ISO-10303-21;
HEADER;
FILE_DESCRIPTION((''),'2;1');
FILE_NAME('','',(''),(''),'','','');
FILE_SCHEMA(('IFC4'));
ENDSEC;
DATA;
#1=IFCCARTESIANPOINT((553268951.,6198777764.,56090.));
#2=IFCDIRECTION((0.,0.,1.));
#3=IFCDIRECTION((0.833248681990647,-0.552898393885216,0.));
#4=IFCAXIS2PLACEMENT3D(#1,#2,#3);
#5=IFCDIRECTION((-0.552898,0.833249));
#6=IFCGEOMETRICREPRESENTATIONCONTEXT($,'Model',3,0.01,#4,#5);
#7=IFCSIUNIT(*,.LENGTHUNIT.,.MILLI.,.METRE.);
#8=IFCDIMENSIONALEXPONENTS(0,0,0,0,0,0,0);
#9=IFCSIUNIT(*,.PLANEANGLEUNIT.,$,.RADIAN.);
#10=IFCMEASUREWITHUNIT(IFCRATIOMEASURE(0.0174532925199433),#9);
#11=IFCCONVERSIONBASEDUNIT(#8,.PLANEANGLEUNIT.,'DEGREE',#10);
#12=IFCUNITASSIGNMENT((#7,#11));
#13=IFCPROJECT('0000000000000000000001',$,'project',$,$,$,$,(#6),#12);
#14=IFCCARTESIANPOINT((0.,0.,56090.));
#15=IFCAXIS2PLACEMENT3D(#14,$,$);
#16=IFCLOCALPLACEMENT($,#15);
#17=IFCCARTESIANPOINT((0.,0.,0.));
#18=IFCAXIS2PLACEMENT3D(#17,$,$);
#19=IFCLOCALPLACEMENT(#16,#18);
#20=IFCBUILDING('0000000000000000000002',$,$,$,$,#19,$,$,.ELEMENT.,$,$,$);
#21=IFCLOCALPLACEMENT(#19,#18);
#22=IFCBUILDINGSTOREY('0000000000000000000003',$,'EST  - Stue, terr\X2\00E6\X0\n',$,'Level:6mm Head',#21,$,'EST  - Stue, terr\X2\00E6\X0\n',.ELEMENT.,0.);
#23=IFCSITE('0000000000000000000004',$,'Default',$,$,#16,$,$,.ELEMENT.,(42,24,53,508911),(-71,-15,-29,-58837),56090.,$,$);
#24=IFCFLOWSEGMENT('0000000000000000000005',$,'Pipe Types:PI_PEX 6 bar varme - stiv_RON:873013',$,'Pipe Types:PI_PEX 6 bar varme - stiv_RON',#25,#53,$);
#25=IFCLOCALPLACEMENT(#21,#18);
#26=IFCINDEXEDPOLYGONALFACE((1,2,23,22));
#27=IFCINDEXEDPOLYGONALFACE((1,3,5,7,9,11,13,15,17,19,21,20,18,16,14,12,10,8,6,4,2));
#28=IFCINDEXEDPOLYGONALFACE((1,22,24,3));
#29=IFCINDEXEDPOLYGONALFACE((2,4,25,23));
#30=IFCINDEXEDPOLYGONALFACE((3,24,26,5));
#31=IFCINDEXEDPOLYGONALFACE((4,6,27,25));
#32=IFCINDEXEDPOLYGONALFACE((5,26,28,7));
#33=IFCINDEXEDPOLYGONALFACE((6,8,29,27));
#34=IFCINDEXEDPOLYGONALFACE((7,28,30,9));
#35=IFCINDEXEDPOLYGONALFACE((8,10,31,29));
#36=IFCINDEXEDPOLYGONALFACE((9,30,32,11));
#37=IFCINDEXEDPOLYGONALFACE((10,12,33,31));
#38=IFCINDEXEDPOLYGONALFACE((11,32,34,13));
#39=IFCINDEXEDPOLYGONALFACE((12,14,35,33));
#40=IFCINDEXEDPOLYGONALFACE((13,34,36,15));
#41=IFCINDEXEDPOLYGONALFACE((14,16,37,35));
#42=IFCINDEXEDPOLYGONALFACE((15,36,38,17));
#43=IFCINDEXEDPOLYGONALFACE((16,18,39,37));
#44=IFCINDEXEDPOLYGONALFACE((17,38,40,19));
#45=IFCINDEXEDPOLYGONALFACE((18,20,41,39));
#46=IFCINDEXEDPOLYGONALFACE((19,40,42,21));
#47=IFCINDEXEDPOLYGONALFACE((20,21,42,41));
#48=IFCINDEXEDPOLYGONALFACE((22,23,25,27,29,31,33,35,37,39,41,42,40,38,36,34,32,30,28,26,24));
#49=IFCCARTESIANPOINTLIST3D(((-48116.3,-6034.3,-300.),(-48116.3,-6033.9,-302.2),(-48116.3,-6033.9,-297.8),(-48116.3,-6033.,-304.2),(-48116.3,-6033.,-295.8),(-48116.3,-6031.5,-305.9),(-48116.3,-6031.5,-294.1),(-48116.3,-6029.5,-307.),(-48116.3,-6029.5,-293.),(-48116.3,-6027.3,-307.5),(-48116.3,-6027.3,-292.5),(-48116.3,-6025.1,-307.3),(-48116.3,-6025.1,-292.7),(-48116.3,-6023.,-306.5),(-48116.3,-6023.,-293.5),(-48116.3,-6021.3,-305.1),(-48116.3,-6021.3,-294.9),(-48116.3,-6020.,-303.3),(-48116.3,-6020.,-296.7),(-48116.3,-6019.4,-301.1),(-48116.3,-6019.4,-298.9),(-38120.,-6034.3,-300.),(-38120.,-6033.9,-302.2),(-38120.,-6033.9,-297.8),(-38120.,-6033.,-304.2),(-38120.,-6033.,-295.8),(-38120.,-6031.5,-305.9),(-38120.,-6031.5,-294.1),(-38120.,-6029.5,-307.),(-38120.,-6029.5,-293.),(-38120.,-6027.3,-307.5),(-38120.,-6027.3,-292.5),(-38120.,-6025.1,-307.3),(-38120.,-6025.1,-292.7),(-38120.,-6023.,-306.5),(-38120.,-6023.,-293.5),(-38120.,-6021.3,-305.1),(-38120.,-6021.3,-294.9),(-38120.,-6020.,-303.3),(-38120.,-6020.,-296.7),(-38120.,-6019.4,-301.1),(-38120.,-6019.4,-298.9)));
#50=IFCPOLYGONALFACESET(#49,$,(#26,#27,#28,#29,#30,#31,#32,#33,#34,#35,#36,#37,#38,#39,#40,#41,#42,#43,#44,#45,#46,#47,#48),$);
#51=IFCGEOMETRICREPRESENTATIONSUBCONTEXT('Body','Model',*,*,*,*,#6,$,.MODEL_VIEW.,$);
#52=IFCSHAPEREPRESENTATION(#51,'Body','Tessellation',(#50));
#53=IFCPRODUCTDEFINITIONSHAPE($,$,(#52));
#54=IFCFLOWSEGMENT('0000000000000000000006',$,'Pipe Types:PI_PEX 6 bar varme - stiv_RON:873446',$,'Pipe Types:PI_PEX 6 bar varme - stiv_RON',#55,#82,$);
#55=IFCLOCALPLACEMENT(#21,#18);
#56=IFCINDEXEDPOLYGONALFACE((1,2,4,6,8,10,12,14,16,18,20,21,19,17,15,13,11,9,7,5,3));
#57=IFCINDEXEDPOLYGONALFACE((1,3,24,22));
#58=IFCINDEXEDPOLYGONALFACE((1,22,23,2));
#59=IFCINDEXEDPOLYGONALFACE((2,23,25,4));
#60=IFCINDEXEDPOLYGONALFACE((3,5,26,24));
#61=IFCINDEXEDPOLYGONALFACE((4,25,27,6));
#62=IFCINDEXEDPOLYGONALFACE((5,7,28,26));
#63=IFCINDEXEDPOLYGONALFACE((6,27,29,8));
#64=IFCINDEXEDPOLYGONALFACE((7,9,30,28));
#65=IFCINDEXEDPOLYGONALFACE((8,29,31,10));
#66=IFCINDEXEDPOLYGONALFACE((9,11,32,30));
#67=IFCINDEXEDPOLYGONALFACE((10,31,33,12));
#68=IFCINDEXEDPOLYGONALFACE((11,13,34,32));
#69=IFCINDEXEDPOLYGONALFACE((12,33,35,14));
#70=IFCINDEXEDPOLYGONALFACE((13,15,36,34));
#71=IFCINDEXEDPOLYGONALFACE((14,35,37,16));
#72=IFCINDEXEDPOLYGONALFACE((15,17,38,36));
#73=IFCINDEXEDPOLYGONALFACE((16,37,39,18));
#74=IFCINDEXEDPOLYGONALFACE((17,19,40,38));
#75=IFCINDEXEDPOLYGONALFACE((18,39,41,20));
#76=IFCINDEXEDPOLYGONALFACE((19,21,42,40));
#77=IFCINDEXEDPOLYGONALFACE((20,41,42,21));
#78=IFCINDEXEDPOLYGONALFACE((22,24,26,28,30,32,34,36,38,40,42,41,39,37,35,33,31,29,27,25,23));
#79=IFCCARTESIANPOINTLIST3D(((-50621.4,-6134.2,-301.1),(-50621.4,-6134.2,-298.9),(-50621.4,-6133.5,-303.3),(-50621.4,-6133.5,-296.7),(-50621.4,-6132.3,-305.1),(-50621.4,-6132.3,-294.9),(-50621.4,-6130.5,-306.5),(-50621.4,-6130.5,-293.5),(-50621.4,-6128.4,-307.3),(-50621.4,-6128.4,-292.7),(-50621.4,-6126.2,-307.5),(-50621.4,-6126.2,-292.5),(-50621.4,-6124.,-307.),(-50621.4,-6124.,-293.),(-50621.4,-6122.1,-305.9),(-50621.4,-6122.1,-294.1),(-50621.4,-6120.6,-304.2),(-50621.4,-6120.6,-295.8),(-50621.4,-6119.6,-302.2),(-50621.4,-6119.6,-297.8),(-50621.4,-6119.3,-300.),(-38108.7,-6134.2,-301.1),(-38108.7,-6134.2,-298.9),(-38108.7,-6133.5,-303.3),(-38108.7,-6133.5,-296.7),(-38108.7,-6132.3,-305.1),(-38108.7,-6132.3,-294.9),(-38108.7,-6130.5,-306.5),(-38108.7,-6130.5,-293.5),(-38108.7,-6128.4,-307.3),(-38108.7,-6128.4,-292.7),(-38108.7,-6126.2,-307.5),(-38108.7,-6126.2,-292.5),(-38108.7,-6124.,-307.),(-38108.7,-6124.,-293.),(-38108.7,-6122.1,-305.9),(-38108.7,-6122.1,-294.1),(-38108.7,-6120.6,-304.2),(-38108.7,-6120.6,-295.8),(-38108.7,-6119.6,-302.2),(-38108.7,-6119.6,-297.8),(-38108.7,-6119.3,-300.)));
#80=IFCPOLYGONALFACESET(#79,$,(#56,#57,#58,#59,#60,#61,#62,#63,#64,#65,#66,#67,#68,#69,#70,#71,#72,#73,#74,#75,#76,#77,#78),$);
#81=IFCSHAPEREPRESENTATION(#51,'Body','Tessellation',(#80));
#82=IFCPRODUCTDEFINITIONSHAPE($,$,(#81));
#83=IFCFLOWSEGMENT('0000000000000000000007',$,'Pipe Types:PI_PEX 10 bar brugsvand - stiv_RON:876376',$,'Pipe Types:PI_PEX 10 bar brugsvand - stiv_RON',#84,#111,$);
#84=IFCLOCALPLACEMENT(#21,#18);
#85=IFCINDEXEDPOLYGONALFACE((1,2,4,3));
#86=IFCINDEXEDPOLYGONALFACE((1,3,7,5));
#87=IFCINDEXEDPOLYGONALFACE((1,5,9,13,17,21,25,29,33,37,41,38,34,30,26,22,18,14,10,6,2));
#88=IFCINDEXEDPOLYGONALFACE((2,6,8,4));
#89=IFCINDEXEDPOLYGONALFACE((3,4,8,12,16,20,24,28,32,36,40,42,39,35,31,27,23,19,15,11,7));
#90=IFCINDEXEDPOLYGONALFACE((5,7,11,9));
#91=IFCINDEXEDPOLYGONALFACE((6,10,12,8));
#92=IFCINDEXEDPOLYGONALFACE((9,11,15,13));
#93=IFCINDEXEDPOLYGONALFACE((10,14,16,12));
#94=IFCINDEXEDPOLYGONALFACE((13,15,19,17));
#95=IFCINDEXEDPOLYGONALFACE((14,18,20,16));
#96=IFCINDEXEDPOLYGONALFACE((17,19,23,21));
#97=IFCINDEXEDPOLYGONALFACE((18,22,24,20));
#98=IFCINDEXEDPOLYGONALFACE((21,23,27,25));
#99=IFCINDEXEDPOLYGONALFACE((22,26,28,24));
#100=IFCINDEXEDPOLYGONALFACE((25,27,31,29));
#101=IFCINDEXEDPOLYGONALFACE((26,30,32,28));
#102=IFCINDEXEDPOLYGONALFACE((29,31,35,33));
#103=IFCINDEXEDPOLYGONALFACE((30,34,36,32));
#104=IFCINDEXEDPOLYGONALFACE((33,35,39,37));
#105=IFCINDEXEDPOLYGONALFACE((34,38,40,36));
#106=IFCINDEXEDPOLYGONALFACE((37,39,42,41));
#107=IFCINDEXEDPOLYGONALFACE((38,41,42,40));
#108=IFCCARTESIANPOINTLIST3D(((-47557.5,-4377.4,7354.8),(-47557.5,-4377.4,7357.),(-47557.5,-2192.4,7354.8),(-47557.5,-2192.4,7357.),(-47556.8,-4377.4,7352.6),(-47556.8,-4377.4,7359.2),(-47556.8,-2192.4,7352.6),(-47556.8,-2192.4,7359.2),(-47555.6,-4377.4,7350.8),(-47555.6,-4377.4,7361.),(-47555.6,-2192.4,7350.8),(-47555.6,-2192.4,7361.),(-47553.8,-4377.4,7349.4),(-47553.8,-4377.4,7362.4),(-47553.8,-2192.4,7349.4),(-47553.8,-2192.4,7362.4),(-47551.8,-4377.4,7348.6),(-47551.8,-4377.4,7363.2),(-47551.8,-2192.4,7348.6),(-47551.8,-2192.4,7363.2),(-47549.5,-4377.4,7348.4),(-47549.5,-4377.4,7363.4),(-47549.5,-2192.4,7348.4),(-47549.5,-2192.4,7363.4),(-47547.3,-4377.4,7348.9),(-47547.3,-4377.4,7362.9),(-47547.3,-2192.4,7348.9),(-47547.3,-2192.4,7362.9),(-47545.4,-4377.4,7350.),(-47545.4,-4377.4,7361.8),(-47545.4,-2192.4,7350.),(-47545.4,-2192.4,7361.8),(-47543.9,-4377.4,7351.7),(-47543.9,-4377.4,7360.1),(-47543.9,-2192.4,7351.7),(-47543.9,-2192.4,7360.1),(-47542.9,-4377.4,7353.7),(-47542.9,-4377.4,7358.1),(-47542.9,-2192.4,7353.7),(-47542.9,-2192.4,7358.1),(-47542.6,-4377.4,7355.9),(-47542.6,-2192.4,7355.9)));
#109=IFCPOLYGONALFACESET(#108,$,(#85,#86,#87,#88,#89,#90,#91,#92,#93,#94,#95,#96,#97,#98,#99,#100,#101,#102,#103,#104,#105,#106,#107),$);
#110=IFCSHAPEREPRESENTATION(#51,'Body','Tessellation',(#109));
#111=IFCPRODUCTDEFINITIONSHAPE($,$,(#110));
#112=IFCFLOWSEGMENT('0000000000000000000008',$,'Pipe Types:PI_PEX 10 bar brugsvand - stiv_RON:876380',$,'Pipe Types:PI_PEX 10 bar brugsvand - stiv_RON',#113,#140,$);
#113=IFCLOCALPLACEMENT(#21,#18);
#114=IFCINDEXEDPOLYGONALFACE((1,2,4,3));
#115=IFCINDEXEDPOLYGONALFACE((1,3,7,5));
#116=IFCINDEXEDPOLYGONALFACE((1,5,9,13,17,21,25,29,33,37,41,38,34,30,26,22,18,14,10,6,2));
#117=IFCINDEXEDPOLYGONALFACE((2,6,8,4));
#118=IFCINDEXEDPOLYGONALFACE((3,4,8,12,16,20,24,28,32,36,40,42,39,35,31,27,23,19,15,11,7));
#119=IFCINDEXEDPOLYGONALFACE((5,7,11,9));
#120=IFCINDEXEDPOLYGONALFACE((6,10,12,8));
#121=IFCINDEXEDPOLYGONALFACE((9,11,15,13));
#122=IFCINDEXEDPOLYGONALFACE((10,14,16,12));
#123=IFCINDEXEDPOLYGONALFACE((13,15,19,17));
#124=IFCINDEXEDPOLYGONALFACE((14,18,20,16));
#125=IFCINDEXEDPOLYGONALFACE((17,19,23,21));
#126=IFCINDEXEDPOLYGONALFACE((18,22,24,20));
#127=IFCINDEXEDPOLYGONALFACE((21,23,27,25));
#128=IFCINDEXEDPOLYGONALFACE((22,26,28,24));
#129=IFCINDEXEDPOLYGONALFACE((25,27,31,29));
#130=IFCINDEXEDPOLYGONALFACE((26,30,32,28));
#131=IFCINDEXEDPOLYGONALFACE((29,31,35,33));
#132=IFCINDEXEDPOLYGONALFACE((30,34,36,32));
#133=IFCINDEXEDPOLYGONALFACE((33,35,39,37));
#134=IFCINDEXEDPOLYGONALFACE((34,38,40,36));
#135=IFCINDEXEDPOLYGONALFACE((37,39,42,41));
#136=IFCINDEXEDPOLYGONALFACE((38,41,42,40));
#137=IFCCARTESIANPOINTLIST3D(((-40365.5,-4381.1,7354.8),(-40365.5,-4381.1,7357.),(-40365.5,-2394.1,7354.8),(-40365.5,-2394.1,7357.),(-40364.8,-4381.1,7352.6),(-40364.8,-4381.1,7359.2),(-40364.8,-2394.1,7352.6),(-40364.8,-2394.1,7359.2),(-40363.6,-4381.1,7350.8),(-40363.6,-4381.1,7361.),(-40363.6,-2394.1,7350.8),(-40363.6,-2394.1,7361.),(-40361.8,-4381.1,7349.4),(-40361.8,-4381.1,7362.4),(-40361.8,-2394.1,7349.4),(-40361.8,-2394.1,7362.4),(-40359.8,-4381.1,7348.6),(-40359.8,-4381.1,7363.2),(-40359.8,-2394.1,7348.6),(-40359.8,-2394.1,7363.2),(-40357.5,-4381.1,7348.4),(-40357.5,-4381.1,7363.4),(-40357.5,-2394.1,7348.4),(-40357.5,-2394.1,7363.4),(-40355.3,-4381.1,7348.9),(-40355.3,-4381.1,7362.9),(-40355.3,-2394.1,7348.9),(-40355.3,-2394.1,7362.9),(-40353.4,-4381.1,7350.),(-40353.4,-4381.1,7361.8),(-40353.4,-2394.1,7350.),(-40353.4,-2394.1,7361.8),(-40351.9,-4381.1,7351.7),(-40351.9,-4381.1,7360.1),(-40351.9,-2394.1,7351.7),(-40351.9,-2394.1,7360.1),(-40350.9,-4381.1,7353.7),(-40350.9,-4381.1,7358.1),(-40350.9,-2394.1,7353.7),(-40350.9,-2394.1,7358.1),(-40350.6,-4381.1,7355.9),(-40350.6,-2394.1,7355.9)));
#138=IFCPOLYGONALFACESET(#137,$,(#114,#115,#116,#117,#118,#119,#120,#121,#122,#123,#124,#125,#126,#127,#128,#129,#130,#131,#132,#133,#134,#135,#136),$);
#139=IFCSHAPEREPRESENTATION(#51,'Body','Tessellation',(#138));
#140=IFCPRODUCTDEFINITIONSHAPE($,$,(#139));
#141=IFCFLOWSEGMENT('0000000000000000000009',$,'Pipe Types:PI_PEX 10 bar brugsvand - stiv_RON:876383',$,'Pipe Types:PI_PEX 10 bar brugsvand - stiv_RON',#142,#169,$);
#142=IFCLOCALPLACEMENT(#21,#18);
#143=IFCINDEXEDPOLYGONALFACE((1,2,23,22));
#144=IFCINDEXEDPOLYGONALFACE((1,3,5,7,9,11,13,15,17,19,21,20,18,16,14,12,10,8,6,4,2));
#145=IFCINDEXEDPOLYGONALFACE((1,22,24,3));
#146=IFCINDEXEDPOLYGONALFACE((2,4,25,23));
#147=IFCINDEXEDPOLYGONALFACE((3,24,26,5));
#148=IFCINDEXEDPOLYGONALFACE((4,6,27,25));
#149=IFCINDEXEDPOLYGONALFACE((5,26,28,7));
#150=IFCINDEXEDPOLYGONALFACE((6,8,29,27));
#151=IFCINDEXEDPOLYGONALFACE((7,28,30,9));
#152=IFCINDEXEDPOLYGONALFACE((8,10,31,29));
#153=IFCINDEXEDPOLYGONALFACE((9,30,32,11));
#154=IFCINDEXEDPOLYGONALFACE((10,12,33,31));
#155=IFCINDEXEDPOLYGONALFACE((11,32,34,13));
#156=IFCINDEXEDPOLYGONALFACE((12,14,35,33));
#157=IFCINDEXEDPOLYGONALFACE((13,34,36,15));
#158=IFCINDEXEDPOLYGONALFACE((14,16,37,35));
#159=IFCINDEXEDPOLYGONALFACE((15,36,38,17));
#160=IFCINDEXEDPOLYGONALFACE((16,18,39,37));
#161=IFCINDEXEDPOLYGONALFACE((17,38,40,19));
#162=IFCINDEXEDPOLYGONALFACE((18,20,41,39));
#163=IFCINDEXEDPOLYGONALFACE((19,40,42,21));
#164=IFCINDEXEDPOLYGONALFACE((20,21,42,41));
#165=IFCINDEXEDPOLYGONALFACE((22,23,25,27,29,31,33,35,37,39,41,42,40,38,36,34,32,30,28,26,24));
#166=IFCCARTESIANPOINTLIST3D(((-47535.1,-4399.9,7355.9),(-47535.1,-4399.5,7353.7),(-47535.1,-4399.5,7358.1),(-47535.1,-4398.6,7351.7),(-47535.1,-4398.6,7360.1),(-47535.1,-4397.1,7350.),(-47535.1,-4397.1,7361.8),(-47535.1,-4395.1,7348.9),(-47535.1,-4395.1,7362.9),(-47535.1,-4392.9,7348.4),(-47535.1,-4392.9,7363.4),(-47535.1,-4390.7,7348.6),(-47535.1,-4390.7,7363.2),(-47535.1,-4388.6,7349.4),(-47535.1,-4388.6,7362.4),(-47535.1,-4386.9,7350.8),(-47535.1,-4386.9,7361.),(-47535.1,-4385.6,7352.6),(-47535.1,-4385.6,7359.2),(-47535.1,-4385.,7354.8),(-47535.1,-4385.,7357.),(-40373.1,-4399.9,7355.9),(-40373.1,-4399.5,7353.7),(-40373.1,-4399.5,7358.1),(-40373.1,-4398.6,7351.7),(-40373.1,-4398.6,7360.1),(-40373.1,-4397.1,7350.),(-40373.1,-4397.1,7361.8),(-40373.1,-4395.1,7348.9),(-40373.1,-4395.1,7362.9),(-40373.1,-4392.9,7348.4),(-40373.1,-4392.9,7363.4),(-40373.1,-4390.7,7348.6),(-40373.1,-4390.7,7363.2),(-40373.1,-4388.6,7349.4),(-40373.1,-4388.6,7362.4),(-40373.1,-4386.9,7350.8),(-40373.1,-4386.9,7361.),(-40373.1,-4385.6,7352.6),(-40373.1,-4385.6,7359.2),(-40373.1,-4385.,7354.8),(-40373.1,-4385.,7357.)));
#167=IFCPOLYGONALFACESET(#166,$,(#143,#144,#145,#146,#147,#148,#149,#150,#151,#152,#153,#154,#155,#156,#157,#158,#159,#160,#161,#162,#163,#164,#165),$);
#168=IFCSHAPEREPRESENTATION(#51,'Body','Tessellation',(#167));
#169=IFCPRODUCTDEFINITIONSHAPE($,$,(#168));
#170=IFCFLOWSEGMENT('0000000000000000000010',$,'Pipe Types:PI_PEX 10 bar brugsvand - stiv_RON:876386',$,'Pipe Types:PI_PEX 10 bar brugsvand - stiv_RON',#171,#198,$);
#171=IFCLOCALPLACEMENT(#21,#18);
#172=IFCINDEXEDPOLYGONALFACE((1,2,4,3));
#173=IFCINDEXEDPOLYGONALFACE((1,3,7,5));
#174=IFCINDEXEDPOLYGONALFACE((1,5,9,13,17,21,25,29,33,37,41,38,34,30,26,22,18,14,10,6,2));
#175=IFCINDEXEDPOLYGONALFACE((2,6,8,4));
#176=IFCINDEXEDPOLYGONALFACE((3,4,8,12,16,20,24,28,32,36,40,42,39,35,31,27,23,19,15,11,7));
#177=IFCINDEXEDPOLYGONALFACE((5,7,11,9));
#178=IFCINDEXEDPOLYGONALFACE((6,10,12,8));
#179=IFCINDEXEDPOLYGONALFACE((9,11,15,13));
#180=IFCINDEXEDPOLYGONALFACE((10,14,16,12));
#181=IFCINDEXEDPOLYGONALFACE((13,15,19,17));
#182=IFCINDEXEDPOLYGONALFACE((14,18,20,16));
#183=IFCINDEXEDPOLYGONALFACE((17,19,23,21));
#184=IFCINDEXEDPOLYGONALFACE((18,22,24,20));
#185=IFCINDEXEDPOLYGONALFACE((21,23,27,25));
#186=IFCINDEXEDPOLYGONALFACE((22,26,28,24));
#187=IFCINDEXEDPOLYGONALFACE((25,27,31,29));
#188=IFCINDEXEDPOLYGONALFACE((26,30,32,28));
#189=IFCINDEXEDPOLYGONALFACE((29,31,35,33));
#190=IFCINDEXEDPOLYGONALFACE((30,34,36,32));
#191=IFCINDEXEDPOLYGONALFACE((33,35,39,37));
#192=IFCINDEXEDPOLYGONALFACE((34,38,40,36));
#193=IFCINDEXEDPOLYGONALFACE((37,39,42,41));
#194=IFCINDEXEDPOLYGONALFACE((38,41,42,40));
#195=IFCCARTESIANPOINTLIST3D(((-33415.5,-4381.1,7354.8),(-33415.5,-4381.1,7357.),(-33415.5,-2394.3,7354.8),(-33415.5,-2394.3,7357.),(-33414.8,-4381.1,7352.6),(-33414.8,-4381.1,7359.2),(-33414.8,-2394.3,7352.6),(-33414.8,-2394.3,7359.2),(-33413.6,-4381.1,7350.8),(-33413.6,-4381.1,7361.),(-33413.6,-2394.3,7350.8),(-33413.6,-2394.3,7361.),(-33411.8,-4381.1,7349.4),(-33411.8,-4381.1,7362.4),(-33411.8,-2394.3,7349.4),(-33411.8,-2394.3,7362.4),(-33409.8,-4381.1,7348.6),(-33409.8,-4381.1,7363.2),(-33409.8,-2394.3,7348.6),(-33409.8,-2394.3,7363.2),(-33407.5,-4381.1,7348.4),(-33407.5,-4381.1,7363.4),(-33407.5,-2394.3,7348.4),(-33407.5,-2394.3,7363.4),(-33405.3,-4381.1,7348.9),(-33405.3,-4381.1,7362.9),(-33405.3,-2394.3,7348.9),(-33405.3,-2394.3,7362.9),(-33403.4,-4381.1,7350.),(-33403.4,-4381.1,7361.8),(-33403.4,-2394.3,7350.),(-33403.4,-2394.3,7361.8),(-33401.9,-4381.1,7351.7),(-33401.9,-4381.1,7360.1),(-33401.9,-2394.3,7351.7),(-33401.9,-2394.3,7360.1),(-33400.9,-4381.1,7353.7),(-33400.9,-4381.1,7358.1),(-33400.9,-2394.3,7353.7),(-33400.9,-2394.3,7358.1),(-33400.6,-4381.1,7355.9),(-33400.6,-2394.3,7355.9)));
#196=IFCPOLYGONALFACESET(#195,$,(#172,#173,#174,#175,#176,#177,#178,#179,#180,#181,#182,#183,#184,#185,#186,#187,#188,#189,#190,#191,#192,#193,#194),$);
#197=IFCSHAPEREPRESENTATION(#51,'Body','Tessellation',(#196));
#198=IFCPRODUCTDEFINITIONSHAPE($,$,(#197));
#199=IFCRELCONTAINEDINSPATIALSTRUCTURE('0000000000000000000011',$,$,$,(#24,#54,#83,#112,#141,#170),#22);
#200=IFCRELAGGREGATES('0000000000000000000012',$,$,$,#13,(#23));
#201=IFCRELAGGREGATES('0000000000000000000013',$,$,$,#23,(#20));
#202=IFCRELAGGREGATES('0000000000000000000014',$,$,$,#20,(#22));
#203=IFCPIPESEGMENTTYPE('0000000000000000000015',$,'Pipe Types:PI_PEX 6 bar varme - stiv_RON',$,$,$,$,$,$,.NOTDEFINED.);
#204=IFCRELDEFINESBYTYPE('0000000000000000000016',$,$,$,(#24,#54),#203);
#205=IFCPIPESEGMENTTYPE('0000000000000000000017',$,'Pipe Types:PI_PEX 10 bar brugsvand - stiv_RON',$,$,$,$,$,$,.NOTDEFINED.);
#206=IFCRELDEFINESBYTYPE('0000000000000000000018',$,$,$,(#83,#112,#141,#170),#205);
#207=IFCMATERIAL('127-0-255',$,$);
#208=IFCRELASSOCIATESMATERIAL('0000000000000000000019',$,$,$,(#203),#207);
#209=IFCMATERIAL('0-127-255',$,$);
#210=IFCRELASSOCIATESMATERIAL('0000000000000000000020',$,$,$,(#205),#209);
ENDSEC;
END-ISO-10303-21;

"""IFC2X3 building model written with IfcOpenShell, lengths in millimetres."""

from ifc_helpers import new_model, entity, si_unit, converted_unit, direction, frame, frame_2d, origin, origin_2d_with_axis, place, context, subcontext, project, spatial, circle, extrude, material, type_object, element, save


model = new_model("IFC2X3")

# Units and contexts
model_context = context("Model", 3, precision=0.01, world=frame((553268951.0, 6198777764.0, 56090.0), z_axis=(0.0, 0.0, 1.0), x_axis=(0.833248681990647, -0.552898393885216, 0.0)), true_north=direction((-0.552898, 0.833249)))
body_context = subcontext(model_context, "Body", "Model", "MODEL_VIEW")
ifc_project = project(units=[si_unit("LENGTHUNIT", "METRE", prefix="MILLI"), converted_unit("PLANEANGLEUNIT", "DEGREE", entity("IfcRatioMeasure", 0.0174532925199433), si_unit("PLANEANGLEUNIT", "RADIAN"), dimensions=[0, 0, 0, 0, 0, 0, 0])], contexts=[model_context])

# Site, building, storey
site_placement = place(None, frame((0.0, 0.0, 56090.0)))
site = spatial("IfcSite", under=ifc_project, at=site_placement, Name="Default", CompositionType="ELEMENT", RefLatitude=(42, 24, 53, 508911), RefLongitude=(-71, -15, -29, -58837), RefElevation=56090.0)
building_placement = place(site_placement, origin())
building = spatial("IfcBuilding", under=site, at=building_placement, CompositionType="ELEMENT")
storey_placement = place(building_placement, frame((0.0, 0.0, 0.0)))
storey = spatial("IfcBuildingStorey", under=building, at=storey_placement, Name="EST  - Stue, terræn", ObjectType="Level:6mm Head", LongName="EST  - Stue, terræn", CompositionType="ELEMENT", Elevation=0.0)

# Flow segments
ifc_material_1 = material(Name="127-0-255")
pipe_segment_type_1 = type_object("IfcPipeSegmentType", Name="Pipe Types:PI_PEX 6 bar varme - stiv_RON", PredefinedType="NOTDEFINED", material=ifc_material_1)
flow_segment_1_placement = place(storey_placement, origin())
element("IfcFlowSegment", 1, at=flow_segment_1_placement, inside=storey, type_object=pipe_segment_type_1, Name="Pipe Types:PI_PEX 6 bar varme - stiv_RON:873013", ObjectType="Pipe Types:PI_PEX 6 bar varme - stiv_RON", context=body_context, shape_type="SweptSolid", body=[
    extrude(circle(Radius=7.5, at=origin_2d_with_axis()), frame((-48116.3, -6026.8, -300.0), z_axis=(1.0, 0.0, 0.0), x_axis=(0.0, -1.0, 0.0)), (0.0, 0.0, 1.0), 9996.4),
])
flow_segment_2_placement = place(storey_placement, origin())
element("IfcFlowSegment", 2, at=flow_segment_2_placement, inside=storey, type_object=pipe_segment_type_1, Name="Pipe Types:PI_PEX 6 bar varme - stiv_RON:873446", ObjectType="Pipe Types:PI_PEX 6 bar varme - stiv_RON", context=body_context, shape_type="SweptSolid", body=[
    extrude(circle(Radius=7.5, at=frame_2d((0.0, 0.0), x_axis=(1.0, 0.0))), frame((-50621.4, -6126.8, -300.0), z_axis=(1.0, 0.0, 0.0), x_axis=(0.0, 1.0, 0.0)), (0.0, 0.0, 1.0), 12512.8),
])
ifc_material_2 = material(Name="0-127-255")
pipe_segment_type_2 = type_object("IfcPipeSegmentType", Name="Pipe Types:PI_PEX 10 bar brugsvand - stiv_RON", PredefinedType="NOTDEFINED", material=ifc_material_2)
flow_segment_3_placement = place(storey_placement, origin())
element("IfcFlowSegment", 3, at=flow_segment_3_placement, inside=storey, type_object=pipe_segment_type_2, Name="Pipe Types:PI_PEX 10 bar brugsvand - stiv_RON:876376", ObjectType="Pipe Types:PI_PEX 10 bar brugsvand - stiv_RON", context=body_context, shape_type="SweptSolid", body=[
    extrude(circle(Radius=7.5, at=origin_2d_with_axis()), frame((-47550.1, -4377.4, 7355.9), z_axis=(0.0, 1.0, 0.0), x_axis=(1.0, 0.0, 0.0)), (0.0, 0.0, 1.0), 2185.0),
])
flow_segment_4_placement = place(storey_placement, origin())
element("IfcFlowSegment", 4, at=flow_segment_4_placement, inside=storey, type_object=pipe_segment_type_2, Name="Pipe Types:PI_PEX 10 bar brugsvand - stiv_RON:876380", ObjectType="Pipe Types:PI_PEX 10 bar brugsvand - stiv_RON", context=body_context, shape_type="SweptSolid", body=[
    extrude(circle(Radius=7.5, at=origin_2d_with_axis()), frame((-40358.1, -4381.1, 7355.9), z_axis=(0.0, 1.0, 0.0), x_axis=(1.0, 0.0, 0.0)), (0.0, 0.0, 1.0), 1987.0),
])
flow_segment_5_placement = place(storey_placement, origin())
element("IfcFlowSegment", 5, at=flow_segment_5_placement, inside=storey, type_object=pipe_segment_type_2, Name="Pipe Types:PI_PEX 10 bar brugsvand - stiv_RON:876383", ObjectType="Pipe Types:PI_PEX 10 bar brugsvand - stiv_RON", context=body_context, shape_type="SweptSolid", body=[
    extrude(circle(Radius=7.5, at=origin_2d_with_axis()), frame((-47535.1, -4392.4, 7355.9), z_axis=(1.0, 0.0, 0.0), x_axis=(0.0, -1.0, 0.0)), (0.0, 0.0, 1.0), 7162.0),
])
flow_segment_6_placement = place(storey_placement, origin())
element("IfcFlowSegment", 6, at=flow_segment_6_placement, inside=storey, type_object=pipe_segment_type_2, Name="Pipe Types:PI_PEX 10 bar brugsvand - stiv_RON:876386", ObjectType="Pipe Types:PI_PEX 10 bar brugsvand - stiv_RON", context=body_context, shape_type="SweptSolid", body=[
    extrude(circle(Radius=7.5, at=origin_2d_with_axis()), frame((-33408.1, -4381.1, 7355.9), z_axis=(0.0, 1.0, 0.0), x_axis=(1.0, 0.0, 0.0)), (0.0, 0.0, 1.0), 1986.8),
])

save(model, "model.ifc")
